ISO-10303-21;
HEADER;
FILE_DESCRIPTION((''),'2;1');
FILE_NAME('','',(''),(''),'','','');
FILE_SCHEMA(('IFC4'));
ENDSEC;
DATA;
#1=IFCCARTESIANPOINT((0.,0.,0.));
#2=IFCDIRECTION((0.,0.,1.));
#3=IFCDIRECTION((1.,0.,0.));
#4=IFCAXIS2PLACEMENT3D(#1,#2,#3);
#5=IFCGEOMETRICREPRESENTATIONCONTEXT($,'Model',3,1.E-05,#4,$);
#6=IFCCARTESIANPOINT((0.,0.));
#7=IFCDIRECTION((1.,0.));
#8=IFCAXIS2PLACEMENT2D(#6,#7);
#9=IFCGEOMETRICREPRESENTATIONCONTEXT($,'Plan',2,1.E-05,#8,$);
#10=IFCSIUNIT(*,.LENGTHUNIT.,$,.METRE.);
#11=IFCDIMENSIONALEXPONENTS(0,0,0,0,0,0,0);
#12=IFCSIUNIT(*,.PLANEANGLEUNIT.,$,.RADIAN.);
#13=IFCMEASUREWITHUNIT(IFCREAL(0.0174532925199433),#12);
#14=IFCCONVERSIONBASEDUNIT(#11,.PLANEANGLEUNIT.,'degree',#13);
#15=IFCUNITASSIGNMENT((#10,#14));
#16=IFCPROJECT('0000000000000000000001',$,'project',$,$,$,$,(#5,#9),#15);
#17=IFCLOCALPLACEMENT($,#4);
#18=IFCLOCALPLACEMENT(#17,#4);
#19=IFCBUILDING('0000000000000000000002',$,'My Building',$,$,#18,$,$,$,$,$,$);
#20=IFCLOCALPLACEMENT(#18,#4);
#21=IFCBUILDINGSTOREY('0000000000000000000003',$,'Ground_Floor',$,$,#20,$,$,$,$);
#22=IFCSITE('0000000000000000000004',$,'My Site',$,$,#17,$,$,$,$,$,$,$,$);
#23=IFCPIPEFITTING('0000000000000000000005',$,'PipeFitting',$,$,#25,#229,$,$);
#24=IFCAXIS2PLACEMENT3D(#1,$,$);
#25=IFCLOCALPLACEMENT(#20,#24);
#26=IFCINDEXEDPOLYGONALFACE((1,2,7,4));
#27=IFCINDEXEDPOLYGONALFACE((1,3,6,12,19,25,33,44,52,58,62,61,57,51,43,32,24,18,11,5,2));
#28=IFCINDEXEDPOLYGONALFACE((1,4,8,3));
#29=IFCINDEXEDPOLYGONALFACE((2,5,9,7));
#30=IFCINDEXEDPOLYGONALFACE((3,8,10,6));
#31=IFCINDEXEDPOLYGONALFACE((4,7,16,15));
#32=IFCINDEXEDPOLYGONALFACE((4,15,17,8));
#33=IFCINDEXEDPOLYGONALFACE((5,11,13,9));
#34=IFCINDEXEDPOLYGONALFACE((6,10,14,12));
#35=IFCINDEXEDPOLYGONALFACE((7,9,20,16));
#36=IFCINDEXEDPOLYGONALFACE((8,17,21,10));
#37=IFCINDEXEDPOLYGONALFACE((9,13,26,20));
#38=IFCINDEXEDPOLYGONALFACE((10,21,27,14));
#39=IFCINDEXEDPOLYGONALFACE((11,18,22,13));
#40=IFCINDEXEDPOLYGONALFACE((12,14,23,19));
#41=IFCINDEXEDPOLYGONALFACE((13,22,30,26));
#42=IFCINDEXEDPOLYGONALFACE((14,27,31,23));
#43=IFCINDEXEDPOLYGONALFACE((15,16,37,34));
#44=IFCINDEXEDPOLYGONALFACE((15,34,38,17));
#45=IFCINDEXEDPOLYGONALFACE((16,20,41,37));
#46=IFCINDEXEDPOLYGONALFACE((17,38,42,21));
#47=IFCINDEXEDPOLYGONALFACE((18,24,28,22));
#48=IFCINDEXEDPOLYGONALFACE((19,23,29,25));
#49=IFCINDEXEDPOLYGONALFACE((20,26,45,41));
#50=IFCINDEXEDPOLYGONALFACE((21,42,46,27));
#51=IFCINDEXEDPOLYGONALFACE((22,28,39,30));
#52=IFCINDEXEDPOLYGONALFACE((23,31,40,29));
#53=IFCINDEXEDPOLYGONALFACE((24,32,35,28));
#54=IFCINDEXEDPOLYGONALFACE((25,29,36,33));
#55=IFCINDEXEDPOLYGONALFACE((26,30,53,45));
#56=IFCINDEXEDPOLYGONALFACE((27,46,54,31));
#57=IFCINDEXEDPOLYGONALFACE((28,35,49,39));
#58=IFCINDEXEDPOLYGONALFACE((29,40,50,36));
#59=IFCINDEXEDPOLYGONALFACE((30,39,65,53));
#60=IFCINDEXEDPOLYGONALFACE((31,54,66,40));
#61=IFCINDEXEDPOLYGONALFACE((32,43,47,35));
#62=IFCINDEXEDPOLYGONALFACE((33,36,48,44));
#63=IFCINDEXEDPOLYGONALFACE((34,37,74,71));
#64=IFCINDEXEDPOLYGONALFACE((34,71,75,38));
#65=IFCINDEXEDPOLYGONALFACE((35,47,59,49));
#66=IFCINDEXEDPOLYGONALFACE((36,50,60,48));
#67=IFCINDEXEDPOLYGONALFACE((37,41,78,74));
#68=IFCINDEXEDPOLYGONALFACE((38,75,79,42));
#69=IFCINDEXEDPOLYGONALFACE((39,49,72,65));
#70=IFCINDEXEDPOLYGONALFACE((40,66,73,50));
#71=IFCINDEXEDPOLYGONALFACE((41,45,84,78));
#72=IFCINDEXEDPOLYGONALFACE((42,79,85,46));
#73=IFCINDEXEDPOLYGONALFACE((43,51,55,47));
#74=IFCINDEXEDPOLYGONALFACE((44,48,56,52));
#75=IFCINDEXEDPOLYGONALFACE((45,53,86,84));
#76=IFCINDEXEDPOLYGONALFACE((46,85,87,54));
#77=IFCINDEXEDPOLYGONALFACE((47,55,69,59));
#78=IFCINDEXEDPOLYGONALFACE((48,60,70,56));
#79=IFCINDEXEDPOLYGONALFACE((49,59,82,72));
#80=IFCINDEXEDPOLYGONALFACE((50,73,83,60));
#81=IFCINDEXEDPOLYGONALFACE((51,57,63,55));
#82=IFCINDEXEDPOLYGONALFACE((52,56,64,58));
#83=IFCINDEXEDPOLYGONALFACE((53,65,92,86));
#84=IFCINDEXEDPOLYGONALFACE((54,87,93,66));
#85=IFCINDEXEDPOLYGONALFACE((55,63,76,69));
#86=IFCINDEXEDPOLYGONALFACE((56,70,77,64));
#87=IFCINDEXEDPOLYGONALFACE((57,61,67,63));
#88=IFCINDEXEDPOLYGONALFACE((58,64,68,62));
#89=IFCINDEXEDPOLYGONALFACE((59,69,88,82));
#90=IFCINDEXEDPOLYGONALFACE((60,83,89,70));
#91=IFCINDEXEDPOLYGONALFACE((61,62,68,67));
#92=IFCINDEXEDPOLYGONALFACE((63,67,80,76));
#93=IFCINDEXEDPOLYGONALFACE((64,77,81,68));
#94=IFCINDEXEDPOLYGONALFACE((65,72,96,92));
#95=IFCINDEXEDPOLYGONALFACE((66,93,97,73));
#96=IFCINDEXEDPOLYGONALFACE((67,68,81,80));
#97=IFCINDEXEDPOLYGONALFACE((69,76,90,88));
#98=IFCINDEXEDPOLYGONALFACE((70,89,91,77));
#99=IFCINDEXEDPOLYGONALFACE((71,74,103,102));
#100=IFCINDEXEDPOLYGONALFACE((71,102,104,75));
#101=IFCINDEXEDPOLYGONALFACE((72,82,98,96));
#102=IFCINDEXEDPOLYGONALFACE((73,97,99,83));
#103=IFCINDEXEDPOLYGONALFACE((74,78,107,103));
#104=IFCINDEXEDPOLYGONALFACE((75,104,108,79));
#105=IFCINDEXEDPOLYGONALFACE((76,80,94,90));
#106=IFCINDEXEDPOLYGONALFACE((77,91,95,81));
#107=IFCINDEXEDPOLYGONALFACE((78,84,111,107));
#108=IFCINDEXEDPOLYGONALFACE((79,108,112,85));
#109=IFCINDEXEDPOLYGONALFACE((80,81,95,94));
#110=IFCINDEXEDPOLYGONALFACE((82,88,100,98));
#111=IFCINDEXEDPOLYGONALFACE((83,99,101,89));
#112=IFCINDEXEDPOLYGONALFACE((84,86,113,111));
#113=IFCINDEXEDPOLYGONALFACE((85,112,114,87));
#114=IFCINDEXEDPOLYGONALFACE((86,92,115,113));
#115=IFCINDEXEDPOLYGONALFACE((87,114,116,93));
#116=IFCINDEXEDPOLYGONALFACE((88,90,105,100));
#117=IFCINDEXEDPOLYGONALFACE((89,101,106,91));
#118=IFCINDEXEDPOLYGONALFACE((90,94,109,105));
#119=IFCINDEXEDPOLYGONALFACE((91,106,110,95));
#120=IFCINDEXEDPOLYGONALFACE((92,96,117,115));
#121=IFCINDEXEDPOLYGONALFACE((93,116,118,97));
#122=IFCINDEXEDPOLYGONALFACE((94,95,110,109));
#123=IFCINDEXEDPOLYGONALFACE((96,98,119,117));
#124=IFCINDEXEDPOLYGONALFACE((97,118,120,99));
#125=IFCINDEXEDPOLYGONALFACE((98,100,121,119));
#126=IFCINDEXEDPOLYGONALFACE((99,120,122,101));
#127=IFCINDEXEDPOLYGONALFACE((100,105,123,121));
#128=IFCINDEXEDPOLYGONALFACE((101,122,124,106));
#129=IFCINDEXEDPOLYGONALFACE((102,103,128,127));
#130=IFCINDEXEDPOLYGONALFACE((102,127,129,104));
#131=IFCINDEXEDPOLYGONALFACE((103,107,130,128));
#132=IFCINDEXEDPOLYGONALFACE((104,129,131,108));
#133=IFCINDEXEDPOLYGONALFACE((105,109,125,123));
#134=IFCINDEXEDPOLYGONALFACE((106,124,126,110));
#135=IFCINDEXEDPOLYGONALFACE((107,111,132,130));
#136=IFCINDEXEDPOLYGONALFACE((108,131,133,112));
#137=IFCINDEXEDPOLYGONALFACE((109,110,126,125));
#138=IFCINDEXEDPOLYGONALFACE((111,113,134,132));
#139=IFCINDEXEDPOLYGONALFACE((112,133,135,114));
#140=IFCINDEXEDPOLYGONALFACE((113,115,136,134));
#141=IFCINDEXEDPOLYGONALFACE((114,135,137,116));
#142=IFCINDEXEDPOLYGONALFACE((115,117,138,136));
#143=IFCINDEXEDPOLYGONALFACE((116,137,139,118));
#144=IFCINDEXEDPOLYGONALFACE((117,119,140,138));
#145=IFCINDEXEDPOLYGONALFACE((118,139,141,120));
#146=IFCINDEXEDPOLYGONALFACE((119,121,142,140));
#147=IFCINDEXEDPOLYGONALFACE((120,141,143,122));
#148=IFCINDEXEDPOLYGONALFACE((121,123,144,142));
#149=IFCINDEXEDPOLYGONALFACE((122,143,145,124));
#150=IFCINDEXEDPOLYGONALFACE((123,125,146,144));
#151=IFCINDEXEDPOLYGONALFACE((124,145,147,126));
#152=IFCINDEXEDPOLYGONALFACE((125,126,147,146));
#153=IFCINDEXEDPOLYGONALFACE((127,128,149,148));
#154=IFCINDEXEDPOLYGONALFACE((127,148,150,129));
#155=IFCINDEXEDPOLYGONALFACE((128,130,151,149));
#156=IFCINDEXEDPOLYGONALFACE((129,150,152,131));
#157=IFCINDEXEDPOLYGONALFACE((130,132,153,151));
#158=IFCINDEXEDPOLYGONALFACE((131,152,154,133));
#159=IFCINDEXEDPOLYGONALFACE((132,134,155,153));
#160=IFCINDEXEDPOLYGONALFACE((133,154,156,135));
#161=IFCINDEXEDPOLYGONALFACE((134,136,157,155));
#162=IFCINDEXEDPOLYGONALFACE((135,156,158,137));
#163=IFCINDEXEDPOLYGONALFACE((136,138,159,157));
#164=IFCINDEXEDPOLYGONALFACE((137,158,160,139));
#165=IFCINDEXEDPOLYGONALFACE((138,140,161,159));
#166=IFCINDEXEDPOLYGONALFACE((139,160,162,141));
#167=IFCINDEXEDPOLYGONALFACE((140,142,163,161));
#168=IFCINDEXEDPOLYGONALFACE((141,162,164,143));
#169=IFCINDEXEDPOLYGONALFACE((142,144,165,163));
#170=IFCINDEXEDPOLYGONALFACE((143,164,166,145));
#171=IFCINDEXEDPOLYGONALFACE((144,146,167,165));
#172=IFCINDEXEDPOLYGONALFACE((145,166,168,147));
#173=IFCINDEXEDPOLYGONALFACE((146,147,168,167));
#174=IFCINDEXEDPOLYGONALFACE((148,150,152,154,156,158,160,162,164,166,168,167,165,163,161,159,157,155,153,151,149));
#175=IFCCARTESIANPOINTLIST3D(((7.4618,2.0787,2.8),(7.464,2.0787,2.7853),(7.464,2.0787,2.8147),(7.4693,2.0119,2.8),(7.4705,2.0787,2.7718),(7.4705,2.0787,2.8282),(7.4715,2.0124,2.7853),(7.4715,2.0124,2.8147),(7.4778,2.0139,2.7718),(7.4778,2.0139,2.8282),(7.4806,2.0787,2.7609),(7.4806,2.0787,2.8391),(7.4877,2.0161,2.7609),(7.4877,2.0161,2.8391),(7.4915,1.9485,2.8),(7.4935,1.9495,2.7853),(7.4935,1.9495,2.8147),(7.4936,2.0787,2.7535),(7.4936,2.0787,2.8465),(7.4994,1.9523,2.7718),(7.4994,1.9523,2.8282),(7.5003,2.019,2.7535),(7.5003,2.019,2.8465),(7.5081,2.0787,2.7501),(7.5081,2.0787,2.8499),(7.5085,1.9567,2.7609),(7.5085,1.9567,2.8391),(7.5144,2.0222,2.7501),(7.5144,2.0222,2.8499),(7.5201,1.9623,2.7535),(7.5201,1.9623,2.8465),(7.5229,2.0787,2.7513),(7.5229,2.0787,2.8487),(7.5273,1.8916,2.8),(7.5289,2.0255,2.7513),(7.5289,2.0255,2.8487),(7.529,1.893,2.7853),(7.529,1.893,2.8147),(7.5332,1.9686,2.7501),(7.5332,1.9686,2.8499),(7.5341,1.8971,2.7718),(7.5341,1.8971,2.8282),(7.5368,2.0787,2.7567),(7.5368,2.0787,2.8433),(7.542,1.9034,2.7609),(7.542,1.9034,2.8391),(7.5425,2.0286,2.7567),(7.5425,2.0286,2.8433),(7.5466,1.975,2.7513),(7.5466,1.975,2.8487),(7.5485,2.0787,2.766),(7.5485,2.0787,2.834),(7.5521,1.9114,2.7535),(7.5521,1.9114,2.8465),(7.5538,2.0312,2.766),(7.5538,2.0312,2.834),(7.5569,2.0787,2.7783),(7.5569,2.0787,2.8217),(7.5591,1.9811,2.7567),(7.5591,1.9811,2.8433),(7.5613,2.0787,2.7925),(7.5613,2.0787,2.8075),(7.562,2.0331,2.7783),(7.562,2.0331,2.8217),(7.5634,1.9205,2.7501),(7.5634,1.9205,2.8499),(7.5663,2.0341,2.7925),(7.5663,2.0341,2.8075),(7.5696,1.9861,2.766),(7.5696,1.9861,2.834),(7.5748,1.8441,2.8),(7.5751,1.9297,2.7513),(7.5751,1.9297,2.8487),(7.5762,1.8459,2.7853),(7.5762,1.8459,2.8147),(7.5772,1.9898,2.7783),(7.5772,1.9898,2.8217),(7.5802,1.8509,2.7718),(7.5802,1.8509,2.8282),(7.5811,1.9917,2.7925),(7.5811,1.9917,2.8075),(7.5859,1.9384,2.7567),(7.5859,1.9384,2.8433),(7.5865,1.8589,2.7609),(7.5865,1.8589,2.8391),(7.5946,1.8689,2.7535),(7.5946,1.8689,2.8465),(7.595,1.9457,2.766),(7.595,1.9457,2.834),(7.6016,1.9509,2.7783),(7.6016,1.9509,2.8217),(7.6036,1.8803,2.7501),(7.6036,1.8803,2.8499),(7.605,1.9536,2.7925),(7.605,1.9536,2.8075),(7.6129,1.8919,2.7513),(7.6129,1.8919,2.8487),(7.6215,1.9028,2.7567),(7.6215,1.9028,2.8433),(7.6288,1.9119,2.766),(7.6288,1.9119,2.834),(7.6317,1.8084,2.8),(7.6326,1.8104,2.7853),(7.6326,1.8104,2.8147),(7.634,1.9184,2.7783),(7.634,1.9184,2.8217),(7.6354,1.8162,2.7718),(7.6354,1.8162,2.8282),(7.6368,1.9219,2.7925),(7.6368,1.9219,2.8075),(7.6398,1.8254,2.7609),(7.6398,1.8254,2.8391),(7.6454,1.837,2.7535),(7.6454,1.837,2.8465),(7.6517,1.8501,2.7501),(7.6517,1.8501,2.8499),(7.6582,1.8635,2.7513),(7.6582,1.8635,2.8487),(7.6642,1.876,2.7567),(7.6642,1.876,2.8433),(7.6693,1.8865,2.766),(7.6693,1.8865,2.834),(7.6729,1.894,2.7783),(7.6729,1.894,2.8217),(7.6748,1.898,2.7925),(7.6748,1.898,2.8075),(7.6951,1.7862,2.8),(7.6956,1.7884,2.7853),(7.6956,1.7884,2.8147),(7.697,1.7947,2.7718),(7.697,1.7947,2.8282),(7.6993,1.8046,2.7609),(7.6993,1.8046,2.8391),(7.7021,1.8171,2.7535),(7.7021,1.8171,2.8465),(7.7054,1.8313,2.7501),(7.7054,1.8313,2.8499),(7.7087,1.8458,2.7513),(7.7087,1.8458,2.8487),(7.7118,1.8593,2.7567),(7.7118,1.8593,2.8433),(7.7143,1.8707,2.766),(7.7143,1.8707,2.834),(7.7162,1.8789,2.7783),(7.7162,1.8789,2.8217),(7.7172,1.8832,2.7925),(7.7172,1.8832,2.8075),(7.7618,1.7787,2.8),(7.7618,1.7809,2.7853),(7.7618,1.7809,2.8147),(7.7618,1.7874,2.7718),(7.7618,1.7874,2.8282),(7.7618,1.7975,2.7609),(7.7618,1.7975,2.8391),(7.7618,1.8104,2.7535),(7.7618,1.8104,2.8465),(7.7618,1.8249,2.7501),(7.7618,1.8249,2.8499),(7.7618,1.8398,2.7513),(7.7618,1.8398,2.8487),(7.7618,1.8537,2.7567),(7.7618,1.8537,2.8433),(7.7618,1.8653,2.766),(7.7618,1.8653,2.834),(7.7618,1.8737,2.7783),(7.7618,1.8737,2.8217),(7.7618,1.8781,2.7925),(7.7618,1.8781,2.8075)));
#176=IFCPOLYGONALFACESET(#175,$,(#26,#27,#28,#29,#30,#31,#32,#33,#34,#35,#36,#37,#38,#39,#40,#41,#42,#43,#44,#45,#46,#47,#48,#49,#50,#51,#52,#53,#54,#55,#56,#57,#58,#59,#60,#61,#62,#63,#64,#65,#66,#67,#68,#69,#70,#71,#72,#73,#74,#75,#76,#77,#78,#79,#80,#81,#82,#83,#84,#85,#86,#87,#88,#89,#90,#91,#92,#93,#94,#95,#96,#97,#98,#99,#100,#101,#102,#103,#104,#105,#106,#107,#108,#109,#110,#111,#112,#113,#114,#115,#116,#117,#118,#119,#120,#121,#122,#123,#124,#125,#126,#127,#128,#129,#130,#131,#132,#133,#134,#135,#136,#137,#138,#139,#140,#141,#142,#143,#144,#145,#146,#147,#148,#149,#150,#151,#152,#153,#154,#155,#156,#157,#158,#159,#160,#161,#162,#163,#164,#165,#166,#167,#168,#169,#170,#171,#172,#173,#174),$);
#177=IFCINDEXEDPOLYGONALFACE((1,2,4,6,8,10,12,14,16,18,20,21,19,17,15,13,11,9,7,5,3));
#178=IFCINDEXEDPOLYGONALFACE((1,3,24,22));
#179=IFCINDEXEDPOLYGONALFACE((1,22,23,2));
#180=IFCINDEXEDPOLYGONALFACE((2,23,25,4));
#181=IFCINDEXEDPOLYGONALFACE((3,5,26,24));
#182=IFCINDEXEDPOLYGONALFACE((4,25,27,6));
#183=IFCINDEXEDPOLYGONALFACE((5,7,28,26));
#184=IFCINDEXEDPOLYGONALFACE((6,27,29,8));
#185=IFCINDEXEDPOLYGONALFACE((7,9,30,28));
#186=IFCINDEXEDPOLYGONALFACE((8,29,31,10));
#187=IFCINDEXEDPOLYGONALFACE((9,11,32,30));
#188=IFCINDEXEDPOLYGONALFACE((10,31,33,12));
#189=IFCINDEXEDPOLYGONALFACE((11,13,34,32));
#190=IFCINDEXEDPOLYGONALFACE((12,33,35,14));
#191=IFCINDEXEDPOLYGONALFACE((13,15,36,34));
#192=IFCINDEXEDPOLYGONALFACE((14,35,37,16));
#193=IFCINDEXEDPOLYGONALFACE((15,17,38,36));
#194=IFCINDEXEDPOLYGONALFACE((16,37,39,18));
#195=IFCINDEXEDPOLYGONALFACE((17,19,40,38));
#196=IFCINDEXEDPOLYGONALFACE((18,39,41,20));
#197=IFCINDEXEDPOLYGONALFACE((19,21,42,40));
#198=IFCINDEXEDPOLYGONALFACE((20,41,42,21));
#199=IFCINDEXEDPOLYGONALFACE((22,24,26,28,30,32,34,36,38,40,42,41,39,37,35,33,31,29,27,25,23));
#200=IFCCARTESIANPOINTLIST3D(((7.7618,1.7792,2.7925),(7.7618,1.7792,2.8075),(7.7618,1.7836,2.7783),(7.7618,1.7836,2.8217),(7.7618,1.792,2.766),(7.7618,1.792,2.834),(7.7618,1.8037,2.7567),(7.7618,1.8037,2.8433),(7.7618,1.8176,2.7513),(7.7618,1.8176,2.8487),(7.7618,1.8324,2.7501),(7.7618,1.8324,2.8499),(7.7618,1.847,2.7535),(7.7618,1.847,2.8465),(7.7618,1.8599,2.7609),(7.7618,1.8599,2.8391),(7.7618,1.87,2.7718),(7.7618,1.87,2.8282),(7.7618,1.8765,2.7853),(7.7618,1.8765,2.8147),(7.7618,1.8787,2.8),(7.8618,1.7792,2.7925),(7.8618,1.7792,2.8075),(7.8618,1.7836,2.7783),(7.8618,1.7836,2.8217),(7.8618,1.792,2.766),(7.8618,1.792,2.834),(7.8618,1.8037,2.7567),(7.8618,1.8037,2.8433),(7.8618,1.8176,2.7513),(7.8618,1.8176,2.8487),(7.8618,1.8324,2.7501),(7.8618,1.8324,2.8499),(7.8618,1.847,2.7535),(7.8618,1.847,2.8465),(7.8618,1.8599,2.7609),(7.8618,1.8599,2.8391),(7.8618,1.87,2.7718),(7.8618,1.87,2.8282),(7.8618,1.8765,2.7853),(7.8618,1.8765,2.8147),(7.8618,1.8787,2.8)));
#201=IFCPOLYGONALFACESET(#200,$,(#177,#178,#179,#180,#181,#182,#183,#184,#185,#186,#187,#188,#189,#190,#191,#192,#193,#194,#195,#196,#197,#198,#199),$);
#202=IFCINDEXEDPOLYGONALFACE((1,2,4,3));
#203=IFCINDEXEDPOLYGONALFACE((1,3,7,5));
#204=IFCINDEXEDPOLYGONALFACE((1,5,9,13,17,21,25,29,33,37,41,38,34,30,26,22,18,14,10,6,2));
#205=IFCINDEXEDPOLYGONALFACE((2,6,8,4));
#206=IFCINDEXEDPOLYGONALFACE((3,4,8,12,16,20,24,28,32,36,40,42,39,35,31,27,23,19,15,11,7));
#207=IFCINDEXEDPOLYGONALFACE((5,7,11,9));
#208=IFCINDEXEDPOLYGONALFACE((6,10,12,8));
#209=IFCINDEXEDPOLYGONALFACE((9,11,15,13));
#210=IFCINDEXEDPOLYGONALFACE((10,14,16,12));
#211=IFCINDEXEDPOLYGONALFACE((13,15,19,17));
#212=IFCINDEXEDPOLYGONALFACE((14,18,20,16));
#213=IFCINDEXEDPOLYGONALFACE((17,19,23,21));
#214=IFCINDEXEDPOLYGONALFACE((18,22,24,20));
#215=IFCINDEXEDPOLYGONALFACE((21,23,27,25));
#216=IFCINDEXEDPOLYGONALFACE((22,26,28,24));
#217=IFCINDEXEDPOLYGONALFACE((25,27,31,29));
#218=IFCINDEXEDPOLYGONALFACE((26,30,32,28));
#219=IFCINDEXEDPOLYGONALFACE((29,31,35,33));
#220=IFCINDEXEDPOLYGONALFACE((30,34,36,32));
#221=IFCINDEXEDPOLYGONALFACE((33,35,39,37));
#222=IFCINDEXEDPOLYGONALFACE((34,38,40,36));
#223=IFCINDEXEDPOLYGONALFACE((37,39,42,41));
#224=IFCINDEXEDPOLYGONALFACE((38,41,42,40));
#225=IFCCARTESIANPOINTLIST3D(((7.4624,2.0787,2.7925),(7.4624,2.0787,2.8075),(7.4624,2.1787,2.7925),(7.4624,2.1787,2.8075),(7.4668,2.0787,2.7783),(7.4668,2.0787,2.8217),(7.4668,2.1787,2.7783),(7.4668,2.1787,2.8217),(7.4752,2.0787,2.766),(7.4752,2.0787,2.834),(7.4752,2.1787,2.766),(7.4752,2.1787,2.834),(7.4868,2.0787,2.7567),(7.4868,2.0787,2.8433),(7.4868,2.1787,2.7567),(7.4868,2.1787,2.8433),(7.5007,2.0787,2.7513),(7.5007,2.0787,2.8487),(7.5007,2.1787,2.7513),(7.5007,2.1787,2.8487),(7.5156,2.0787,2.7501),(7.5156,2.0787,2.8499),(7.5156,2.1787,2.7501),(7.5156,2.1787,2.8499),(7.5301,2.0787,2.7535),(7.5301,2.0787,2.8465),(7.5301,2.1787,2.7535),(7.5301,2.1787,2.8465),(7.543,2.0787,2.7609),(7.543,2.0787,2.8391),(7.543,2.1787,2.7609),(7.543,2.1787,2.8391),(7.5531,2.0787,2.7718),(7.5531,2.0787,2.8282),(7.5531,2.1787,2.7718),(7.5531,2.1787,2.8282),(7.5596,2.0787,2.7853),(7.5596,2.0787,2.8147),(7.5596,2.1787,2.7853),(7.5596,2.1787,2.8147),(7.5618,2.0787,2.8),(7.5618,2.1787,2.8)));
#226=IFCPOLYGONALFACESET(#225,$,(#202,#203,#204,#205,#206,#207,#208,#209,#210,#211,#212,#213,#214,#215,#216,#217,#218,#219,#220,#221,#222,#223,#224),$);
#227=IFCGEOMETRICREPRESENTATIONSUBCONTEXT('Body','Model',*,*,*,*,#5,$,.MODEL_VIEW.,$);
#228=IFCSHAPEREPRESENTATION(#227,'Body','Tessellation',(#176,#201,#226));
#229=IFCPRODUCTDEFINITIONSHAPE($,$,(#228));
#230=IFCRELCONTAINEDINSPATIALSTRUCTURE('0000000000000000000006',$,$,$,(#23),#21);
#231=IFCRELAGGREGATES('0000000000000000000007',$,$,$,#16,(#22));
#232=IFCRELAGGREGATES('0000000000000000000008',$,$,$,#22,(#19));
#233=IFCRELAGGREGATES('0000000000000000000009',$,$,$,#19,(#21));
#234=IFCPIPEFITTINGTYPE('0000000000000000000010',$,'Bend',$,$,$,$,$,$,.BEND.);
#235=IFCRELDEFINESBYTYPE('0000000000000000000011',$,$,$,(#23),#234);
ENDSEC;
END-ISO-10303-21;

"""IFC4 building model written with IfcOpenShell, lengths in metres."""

from ifc_helpers import new_model, entity, si_unit, converted_unit, frame, origin_with_axes, origin_2d_with_axis, place, context, subcontext, project, spatial, circle, extrude, source, transform, mapped, type_object, type_shapes, element, save


model = new_model("IFC4")

# Units and contexts
model_context = context("Model", 3, precision=1e-05, world=origin_with_axes())
plan_context = context("Plan", 2, precision=1e-05, world=origin_2d_with_axis())
body_context = subcontext(model_context, "Body", "Model", "MODEL_VIEW")
ifc_project = project(units=[si_unit("LENGTHUNIT", "METRE"), converted_unit("PLANEANGLEUNIT", "degree", entity("IfcReal", 0.0174532925199433), si_unit("PLANEANGLEUNIT", "RADIAN"), dimensions=[0, 0, 0, 0, 0, 0, 0])], contexts=[model_context, plan_context])

# Site, building, storey
site_placement = place(None, origin_with_axes())
site = spatial("IfcSite", under=ifc_project, at=site_placement, Name="My Site")
building_placement = place(site_placement, origin_with_axes())
building = spatial("IfcBuilding", under=site, at=building_placement, Name="My Building")
storey_placement = place(building_placement, origin_with_axes())
storey = spatial("IfcBuildingStorey", under=building, at=storey_placement, Name="Ground_Floor")

# Pipe fitting
pipe_fitting_type = type_object("IfcPipeFittingType", Name="Bend", PredefinedType="BEND")
shared_shape = source(origin_with_axes(), body_context, "Body", "SolidModel", [
    entity("IfcSweptDiskSolid", entity("IfcIndexedPolyCurve", entity("IfcCartesianPointList3D", [[0.0, 0.0, -0.1], [0.0732, 0.0, -0.2768], [0.25, 0.0, -0.35]]), [entity("IfcArcIndex", [1, 2, 3])]), 0.05),
    extrude(circle(Radius=0.05), origin_with_axes(), (0.0, 0.0, -1.0), 0.1),
    extrude(circle(Radius=0.05), frame((0.25, 0.0, -0.35), z_axis=(1.0, 0.0, 0.0), x_axis=(0.0, 0.0, 1.0)), (0.0, 0.0, 1.0), 0.1),
])
type_shapes(pipe_fitting_type, [shared_shape])
for number, where, z_axis, x_axis, name in (
    (1, (7.8618, 1.8287, 2.8), (1.0, 0.0, 0.0), (0.0, 1.0, 0.0), "PipeFitting"),
):
    element("IfcPipeFitting", number, at=place(storey_placement, frame(where, z_axis=z_axis, x_axis=x_axis)), inside=storey, type_object=pipe_fitting_type, Name=name, context=body_context, shape_type="MappedRepresentation", body=[
        mapped(shared_shape, transform((0.0, 0.0, 0.0), x_axis=(1.0, 0.0, 0.0), y_axis=(0.0, 1.0, 0.0), z_axis=(0.0, 0.0, 1.0), scale=1.0)),
    ])

save(model, "model.ifc")
